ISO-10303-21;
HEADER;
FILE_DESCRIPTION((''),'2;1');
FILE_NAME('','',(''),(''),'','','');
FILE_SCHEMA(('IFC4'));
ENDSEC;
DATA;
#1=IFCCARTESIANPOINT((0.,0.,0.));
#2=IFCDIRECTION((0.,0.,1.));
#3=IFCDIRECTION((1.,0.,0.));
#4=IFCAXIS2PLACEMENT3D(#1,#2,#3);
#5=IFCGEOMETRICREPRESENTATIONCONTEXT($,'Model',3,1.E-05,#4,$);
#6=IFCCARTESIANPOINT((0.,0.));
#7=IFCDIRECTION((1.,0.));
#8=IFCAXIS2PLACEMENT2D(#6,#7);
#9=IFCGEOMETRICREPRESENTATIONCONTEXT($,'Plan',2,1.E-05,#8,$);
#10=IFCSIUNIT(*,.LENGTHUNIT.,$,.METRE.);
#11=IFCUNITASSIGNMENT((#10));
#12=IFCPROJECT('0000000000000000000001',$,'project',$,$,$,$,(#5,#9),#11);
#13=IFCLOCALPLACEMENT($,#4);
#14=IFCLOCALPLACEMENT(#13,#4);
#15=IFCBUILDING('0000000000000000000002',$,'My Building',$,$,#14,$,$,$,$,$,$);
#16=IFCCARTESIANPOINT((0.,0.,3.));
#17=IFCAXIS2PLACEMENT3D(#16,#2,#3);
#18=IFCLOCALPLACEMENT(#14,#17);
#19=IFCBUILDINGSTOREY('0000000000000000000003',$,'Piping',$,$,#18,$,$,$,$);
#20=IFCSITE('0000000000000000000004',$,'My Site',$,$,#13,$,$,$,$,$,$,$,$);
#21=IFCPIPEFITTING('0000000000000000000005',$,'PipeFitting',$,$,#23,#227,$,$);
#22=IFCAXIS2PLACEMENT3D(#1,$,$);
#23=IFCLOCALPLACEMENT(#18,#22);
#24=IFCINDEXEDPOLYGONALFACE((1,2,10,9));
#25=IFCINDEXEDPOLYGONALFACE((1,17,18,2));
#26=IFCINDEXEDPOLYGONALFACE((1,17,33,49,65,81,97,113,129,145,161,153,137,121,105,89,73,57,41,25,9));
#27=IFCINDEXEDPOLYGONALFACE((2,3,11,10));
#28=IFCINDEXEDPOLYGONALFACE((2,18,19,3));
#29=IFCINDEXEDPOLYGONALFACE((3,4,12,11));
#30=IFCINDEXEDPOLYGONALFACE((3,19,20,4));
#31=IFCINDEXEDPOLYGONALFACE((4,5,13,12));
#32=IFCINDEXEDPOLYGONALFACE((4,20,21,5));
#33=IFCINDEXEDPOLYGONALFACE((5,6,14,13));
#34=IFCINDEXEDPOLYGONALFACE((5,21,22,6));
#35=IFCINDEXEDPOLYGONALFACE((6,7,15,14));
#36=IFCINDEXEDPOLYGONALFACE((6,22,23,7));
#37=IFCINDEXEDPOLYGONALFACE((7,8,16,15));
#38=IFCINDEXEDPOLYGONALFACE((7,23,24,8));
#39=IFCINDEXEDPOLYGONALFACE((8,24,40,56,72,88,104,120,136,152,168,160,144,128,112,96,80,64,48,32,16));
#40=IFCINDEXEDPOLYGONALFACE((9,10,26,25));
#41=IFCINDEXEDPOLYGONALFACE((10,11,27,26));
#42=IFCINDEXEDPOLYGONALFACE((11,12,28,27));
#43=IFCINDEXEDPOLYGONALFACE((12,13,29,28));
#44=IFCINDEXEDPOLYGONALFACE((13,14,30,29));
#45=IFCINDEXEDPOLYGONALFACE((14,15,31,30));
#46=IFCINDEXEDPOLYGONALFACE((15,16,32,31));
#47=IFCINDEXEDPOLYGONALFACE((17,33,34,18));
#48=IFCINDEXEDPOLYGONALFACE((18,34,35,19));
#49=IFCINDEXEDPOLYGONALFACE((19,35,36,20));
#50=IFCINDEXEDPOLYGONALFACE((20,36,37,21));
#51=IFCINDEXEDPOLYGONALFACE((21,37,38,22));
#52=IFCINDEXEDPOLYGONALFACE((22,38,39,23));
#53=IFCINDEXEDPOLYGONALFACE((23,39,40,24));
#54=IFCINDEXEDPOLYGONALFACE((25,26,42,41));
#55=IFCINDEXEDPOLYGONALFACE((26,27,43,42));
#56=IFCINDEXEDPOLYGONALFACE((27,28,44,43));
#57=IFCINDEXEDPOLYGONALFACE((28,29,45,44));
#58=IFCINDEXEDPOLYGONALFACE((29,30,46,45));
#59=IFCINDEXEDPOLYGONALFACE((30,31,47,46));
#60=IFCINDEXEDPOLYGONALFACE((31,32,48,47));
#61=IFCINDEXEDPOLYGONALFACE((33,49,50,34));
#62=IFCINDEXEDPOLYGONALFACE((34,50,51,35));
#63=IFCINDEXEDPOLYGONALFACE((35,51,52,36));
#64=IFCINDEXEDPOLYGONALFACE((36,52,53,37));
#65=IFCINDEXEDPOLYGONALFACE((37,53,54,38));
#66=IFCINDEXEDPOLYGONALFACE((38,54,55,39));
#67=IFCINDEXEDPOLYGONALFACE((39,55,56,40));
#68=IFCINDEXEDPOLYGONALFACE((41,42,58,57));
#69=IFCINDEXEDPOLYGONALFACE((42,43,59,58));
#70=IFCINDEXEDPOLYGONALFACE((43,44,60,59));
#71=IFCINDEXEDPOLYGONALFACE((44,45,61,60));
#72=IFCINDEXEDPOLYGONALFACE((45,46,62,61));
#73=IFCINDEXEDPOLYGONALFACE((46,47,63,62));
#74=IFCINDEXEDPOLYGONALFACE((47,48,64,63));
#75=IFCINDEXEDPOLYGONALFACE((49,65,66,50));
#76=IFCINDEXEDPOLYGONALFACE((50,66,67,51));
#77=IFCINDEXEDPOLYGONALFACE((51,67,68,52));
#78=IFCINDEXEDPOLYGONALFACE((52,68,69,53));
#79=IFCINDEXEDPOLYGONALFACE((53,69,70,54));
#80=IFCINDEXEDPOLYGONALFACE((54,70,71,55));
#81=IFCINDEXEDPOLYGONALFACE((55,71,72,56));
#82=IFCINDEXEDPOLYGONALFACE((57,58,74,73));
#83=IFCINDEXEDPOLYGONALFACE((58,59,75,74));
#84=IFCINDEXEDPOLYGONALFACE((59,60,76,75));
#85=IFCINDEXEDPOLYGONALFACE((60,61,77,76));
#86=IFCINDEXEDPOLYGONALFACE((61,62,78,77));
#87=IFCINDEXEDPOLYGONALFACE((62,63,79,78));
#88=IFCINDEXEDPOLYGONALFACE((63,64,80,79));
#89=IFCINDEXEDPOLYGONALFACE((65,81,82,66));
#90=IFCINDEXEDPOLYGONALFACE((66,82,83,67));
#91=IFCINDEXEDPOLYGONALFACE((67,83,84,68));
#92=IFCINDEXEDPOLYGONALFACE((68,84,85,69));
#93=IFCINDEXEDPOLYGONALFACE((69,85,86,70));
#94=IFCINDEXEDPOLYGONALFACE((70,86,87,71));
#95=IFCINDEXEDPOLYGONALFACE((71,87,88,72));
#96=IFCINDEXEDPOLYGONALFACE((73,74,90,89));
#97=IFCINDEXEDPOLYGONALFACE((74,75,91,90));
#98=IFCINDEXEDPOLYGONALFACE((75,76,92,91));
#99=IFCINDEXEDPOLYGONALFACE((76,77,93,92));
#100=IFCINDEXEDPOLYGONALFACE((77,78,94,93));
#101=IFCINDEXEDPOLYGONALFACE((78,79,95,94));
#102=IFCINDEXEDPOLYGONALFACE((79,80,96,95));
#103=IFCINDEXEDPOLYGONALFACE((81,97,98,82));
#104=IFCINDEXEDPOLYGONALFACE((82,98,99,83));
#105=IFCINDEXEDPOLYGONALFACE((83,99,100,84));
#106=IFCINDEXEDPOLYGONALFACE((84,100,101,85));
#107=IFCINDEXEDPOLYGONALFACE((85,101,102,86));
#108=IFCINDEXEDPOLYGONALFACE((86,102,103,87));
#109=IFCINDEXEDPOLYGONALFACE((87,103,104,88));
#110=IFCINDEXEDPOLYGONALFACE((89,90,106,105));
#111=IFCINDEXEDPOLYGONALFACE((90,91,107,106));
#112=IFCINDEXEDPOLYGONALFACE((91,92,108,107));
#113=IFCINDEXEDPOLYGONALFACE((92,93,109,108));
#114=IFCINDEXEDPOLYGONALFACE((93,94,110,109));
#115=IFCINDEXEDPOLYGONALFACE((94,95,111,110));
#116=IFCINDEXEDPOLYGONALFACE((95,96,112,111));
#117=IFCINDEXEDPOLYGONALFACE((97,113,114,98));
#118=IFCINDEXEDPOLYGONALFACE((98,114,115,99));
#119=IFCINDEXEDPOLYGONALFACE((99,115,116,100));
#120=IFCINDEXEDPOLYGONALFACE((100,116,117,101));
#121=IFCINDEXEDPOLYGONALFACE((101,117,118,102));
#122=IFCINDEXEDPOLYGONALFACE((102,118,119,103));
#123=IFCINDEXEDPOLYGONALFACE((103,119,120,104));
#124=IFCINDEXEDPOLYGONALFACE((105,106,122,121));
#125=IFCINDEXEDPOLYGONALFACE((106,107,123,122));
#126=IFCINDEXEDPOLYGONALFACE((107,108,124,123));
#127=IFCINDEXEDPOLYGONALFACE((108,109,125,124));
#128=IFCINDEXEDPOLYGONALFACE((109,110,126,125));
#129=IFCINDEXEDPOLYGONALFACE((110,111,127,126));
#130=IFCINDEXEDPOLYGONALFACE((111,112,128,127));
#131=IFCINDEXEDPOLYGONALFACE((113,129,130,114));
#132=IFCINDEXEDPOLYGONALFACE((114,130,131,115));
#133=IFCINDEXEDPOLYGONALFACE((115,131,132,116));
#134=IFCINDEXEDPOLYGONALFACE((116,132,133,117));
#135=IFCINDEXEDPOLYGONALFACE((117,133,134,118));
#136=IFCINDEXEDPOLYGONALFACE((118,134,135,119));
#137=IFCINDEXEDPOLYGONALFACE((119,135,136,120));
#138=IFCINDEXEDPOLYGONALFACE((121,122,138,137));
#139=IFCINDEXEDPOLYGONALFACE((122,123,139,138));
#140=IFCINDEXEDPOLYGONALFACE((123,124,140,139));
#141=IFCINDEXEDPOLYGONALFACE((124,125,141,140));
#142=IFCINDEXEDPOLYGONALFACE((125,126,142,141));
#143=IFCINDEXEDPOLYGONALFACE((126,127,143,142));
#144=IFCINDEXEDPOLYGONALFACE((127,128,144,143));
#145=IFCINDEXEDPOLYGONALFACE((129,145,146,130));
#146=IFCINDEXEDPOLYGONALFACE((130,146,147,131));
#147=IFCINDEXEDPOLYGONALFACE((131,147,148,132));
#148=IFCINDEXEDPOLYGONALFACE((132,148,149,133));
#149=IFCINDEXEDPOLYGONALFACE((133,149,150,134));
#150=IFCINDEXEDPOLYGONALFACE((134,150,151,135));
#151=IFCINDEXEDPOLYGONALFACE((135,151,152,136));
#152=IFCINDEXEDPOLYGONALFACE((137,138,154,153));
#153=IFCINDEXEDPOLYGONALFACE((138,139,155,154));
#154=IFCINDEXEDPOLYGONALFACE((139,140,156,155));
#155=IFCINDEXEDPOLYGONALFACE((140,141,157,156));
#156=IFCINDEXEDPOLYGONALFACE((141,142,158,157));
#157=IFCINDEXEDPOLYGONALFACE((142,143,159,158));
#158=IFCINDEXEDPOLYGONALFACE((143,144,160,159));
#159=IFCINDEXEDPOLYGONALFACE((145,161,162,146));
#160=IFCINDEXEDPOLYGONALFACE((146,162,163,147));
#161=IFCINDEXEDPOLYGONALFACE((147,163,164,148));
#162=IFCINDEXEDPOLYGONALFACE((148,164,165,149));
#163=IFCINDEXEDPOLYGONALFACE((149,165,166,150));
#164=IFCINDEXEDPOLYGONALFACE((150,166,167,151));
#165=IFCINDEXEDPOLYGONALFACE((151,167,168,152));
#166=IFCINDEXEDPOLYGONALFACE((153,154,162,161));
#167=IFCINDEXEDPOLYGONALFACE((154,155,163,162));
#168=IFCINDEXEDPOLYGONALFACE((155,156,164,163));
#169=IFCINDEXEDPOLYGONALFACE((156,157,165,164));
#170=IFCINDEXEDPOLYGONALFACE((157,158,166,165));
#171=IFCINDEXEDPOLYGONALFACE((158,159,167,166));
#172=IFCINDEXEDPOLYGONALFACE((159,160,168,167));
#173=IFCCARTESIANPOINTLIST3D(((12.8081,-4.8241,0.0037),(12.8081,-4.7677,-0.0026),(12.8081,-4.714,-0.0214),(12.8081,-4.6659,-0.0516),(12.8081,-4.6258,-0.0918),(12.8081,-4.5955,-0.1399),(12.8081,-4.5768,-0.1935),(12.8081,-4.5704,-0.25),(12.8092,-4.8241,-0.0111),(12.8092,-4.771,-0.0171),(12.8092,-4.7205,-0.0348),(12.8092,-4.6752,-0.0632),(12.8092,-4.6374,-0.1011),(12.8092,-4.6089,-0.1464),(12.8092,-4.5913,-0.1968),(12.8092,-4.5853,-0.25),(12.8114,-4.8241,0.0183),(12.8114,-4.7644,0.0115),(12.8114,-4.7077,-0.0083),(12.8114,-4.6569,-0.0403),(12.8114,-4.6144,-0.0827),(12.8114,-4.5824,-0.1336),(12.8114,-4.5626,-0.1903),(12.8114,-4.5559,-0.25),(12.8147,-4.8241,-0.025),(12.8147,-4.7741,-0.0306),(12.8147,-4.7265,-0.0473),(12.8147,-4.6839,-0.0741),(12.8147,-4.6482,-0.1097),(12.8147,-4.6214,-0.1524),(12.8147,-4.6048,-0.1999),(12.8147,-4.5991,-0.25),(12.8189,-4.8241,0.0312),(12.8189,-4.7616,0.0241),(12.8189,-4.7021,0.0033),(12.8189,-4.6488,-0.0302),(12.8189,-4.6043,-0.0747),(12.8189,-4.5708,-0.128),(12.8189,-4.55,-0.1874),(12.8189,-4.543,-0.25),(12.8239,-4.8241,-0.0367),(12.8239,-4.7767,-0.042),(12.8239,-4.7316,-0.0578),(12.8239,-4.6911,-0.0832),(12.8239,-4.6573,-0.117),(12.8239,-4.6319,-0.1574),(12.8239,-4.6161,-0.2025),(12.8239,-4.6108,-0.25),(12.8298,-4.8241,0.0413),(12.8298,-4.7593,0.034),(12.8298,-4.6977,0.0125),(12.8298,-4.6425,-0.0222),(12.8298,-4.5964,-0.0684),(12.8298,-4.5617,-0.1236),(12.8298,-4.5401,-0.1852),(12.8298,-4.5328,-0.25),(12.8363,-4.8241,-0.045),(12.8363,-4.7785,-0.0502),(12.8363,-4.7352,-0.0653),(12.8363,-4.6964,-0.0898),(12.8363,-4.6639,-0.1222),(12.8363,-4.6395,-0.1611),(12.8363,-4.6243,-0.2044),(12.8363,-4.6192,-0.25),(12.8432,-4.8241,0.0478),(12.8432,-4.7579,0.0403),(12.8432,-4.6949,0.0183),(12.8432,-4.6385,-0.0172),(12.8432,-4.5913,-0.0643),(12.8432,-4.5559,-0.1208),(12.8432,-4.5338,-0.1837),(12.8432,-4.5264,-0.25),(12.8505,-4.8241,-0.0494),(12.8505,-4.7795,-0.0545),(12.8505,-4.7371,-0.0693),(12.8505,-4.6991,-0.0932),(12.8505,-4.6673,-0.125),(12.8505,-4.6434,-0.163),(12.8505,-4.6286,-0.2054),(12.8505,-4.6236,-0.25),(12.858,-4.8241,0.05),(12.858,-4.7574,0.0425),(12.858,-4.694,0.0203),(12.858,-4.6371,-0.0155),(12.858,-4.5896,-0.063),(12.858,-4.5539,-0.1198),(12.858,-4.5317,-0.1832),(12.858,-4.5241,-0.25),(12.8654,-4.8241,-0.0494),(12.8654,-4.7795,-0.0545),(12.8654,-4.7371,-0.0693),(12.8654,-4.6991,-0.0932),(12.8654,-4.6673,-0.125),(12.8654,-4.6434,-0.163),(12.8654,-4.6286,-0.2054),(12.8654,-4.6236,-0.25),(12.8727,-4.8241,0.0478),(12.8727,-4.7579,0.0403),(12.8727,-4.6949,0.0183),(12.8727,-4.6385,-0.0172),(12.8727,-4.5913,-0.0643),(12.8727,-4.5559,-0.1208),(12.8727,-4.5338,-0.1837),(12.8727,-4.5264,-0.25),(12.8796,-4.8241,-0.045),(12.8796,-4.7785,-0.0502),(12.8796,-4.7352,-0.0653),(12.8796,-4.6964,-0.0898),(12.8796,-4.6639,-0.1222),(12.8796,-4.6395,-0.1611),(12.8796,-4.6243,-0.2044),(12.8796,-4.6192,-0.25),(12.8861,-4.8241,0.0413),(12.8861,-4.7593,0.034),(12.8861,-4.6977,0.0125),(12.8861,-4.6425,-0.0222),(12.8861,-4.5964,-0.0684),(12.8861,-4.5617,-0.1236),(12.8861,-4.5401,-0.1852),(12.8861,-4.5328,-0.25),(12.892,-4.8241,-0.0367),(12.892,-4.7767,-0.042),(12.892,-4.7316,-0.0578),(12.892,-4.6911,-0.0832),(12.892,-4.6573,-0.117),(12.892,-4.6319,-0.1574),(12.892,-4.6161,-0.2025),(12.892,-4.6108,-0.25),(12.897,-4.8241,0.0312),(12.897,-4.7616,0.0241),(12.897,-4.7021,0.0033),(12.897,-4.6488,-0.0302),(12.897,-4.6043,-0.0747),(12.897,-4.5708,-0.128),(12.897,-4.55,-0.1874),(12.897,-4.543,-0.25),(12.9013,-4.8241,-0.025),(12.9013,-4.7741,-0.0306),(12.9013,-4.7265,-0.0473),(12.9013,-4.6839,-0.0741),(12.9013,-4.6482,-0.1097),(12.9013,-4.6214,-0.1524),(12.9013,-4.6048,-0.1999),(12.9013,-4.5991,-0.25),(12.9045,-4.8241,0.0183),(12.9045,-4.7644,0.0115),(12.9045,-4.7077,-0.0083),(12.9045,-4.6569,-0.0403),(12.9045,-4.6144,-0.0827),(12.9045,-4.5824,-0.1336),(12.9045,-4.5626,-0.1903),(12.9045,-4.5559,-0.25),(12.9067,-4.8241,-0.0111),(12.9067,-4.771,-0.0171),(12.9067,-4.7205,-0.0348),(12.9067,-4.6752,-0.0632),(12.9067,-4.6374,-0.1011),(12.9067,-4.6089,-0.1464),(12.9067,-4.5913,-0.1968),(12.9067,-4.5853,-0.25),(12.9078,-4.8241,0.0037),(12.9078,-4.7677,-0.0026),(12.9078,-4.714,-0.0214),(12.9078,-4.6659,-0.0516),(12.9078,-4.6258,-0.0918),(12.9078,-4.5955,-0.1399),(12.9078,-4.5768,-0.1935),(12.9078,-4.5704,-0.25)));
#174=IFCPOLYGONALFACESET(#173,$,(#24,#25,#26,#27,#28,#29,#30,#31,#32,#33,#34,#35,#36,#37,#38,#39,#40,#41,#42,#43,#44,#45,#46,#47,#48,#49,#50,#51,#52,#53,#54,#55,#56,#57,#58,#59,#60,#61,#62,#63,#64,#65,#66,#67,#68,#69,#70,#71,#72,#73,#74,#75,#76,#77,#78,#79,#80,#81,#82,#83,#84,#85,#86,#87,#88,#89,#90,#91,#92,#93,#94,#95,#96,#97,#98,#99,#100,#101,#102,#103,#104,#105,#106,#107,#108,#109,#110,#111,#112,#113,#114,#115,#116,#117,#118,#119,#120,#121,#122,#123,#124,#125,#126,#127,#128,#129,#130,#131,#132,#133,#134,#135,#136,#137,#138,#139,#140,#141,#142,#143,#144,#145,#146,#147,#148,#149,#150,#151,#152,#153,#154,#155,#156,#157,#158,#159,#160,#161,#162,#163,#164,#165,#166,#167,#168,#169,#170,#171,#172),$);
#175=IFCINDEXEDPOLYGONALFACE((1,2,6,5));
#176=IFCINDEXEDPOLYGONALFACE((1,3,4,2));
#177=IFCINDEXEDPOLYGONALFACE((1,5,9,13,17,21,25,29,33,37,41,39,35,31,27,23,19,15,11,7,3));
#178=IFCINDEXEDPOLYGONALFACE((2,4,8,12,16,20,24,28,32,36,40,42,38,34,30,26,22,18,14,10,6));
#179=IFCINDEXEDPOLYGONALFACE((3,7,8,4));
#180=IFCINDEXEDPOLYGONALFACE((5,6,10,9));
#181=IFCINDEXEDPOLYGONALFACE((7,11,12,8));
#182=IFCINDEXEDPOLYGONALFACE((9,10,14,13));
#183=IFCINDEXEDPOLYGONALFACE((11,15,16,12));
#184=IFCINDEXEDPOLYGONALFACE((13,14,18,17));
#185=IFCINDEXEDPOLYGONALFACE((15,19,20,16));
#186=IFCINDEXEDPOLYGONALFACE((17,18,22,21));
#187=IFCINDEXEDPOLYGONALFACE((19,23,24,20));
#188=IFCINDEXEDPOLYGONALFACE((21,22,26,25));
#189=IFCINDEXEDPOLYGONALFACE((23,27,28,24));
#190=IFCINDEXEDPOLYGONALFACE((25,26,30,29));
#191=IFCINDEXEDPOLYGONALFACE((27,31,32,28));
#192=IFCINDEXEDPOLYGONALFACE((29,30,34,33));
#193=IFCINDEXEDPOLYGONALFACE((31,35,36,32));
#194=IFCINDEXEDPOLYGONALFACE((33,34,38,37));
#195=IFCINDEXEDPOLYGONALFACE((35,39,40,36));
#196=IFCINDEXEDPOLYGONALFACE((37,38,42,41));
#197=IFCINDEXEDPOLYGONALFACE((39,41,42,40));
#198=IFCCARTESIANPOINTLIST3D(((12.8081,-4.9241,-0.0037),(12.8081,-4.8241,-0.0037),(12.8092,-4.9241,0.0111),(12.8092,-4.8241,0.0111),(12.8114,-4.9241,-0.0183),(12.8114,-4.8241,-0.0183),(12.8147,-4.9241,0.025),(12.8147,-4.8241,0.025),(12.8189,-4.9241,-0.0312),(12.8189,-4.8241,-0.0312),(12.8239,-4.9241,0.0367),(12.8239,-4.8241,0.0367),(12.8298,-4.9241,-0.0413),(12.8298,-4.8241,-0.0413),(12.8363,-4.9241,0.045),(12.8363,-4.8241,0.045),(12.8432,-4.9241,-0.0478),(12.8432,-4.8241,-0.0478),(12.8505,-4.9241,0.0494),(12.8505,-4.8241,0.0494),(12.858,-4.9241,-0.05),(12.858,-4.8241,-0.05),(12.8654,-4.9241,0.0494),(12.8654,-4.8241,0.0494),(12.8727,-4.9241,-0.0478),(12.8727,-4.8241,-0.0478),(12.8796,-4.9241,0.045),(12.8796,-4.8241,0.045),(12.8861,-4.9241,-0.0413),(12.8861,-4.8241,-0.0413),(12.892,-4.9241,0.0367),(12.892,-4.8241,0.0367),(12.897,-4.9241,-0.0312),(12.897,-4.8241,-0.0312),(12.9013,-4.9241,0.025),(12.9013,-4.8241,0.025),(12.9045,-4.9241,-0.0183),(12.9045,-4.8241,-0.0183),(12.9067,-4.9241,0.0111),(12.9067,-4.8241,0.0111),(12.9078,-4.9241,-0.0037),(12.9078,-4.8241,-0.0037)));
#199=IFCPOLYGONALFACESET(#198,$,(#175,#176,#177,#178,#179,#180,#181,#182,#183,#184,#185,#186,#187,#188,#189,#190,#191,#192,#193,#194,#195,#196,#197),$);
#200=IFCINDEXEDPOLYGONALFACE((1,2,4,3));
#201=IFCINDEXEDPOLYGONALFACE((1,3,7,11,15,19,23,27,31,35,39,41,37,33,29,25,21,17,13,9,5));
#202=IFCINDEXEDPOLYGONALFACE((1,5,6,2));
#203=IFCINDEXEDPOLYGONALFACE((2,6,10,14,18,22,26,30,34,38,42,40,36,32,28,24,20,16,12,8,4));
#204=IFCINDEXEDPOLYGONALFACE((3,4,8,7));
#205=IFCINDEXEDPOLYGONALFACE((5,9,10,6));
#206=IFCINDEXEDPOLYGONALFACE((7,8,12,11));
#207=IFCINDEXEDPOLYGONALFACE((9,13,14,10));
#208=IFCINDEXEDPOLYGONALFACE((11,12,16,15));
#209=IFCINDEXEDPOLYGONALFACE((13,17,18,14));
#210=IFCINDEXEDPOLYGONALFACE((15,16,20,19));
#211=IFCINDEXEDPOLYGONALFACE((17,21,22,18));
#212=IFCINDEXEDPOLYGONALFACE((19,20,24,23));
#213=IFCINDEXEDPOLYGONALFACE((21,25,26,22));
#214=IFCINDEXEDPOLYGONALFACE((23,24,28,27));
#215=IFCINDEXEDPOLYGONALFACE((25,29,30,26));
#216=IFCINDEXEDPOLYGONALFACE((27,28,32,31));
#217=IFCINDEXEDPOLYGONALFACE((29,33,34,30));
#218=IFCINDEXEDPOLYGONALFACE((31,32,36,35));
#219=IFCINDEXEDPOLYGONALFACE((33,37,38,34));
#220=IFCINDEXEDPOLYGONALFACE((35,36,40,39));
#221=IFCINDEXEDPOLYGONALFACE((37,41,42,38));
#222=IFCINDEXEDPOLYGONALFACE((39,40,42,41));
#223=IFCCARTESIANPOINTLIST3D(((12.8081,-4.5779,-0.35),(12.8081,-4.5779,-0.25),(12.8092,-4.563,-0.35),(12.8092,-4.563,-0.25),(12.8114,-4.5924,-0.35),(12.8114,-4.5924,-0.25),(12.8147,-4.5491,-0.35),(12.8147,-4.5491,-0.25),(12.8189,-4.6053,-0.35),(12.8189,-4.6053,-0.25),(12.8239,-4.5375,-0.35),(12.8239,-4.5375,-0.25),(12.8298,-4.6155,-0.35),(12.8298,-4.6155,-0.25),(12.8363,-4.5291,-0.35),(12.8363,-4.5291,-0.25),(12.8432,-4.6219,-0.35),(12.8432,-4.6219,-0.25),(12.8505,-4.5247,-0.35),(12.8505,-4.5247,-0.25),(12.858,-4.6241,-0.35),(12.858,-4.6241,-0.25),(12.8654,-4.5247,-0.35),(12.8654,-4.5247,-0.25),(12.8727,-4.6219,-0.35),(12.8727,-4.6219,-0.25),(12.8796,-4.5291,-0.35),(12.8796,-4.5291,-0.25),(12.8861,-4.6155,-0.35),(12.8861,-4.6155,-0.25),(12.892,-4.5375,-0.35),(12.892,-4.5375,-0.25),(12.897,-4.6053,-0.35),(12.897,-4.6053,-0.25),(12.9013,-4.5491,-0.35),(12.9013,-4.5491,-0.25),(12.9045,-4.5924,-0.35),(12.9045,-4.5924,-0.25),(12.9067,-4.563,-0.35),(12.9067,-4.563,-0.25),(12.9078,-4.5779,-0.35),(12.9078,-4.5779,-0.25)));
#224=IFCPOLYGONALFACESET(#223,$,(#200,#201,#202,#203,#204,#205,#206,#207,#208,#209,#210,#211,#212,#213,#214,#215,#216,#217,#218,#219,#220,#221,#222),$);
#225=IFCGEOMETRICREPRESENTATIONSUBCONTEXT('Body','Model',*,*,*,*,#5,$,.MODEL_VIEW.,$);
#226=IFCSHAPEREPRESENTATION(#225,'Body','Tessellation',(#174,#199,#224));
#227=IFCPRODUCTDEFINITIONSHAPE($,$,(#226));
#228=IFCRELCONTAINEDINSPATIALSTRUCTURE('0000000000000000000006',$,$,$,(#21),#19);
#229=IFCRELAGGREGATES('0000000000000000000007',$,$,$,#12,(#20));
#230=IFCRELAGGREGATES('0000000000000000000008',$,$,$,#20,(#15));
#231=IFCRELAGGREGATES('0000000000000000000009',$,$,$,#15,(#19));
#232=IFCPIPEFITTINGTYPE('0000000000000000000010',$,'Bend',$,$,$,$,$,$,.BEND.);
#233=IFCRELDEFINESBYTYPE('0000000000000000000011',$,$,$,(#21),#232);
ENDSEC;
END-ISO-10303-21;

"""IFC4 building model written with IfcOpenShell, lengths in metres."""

from ifc_helpers import new_model, entity, si_unit, frame, origin_with_axes, origin_2d_with_axis, place, context, subcontext, project, spatial, circle, extrude, source, transform, mapped, type_object, type_shapes, element, save


model = new_model("IFC4")

# Units and contexts
model_context = context("Model", 3, precision=1e-05, world=origin_with_axes())
plan_context = context("Plan", 2, precision=1e-05, world=origin_2d_with_axis())
body_context = subcontext(model_context, "Body", "Model", "MODEL_VIEW")
ifc_project = project(units=[si_unit("LENGTHUNIT", "METRE")], contexts=[model_context, plan_context])

# Site, building, storey
site_placement = place(None, origin_with_axes())
site = spatial("IfcSite", under=ifc_project, at=site_placement, Name="My Site")
building_placement = place(site_placement, origin_with_axes())
building = spatial("IfcBuilding", under=site, at=building_placement, Name="My Building")
storey_placement = place(building_placement, frame((0.0, 0.0, 3.0), z_axis=(0.0, 0.0, 1.0), x_axis=(1.0, 0.0, 0.0)))
storey = spatial("IfcBuildingStorey", under=building, at=storey_placement, Name="Piping")

# Pipe fitting
pipe_fitting_type_1 = type_object("IfcPipeFittingType", Name="Bend", PredefinedType="BEND")
shared_shape_1 = source(origin_with_axes(), body_context, "Body", "SolidModel", [
    entity("IfcSweptDiskSolid", entity("IfcIndexedPolyCurve", entity("IfcCartesianPointList3D", [[0.0, 0.0, -0.1], [0.0732, 0.0, -0.2768], [0.25, 0.0, -0.35]]), [entity("IfcArcIndex", [1, 2, 3])]), 0.05),
    extrude(circle(Radius=0.05), origin_with_axes(), (0.0, 0.0, -1.0), 0.1),
    extrude(circle(Radius=0.05), frame((0.25, 0.0, -0.35), z_axis=(1.0, 0.0, 0.0), x_axis=(0.0, 0.0, 1.0)), (0.0, 0.0, 1.0), 0.1),
])
type_shapes(pipe_fitting_type_1, [shared_shape_1])
for number, where, z_axis, x_axis, name in (
    (1, (12.858, -4.9241, 0.0), (0.0, -1.0, 0.0), (0.0, 0.0, -1.0), "PipeFitting"),
):
    element("IfcPipeFitting", number, at=place(storey_placement, frame(where, z_axis=z_axis, x_axis=x_axis)), inside=storey, type_object=pipe_fitting_type_1, Name=name, context=body_context, shape_type="MappedRepresentation", body=[
        mapped(shared_shape_1, transform((0.0, 0.0, 0.0), x_axis=(1.0, 0.0, 0.0), y_axis=(0.0, 1.0, 0.0), z_axis=(0.0, 0.0, 1.0), scale=1.0)),
    ])

save(model, "model.ifc")
